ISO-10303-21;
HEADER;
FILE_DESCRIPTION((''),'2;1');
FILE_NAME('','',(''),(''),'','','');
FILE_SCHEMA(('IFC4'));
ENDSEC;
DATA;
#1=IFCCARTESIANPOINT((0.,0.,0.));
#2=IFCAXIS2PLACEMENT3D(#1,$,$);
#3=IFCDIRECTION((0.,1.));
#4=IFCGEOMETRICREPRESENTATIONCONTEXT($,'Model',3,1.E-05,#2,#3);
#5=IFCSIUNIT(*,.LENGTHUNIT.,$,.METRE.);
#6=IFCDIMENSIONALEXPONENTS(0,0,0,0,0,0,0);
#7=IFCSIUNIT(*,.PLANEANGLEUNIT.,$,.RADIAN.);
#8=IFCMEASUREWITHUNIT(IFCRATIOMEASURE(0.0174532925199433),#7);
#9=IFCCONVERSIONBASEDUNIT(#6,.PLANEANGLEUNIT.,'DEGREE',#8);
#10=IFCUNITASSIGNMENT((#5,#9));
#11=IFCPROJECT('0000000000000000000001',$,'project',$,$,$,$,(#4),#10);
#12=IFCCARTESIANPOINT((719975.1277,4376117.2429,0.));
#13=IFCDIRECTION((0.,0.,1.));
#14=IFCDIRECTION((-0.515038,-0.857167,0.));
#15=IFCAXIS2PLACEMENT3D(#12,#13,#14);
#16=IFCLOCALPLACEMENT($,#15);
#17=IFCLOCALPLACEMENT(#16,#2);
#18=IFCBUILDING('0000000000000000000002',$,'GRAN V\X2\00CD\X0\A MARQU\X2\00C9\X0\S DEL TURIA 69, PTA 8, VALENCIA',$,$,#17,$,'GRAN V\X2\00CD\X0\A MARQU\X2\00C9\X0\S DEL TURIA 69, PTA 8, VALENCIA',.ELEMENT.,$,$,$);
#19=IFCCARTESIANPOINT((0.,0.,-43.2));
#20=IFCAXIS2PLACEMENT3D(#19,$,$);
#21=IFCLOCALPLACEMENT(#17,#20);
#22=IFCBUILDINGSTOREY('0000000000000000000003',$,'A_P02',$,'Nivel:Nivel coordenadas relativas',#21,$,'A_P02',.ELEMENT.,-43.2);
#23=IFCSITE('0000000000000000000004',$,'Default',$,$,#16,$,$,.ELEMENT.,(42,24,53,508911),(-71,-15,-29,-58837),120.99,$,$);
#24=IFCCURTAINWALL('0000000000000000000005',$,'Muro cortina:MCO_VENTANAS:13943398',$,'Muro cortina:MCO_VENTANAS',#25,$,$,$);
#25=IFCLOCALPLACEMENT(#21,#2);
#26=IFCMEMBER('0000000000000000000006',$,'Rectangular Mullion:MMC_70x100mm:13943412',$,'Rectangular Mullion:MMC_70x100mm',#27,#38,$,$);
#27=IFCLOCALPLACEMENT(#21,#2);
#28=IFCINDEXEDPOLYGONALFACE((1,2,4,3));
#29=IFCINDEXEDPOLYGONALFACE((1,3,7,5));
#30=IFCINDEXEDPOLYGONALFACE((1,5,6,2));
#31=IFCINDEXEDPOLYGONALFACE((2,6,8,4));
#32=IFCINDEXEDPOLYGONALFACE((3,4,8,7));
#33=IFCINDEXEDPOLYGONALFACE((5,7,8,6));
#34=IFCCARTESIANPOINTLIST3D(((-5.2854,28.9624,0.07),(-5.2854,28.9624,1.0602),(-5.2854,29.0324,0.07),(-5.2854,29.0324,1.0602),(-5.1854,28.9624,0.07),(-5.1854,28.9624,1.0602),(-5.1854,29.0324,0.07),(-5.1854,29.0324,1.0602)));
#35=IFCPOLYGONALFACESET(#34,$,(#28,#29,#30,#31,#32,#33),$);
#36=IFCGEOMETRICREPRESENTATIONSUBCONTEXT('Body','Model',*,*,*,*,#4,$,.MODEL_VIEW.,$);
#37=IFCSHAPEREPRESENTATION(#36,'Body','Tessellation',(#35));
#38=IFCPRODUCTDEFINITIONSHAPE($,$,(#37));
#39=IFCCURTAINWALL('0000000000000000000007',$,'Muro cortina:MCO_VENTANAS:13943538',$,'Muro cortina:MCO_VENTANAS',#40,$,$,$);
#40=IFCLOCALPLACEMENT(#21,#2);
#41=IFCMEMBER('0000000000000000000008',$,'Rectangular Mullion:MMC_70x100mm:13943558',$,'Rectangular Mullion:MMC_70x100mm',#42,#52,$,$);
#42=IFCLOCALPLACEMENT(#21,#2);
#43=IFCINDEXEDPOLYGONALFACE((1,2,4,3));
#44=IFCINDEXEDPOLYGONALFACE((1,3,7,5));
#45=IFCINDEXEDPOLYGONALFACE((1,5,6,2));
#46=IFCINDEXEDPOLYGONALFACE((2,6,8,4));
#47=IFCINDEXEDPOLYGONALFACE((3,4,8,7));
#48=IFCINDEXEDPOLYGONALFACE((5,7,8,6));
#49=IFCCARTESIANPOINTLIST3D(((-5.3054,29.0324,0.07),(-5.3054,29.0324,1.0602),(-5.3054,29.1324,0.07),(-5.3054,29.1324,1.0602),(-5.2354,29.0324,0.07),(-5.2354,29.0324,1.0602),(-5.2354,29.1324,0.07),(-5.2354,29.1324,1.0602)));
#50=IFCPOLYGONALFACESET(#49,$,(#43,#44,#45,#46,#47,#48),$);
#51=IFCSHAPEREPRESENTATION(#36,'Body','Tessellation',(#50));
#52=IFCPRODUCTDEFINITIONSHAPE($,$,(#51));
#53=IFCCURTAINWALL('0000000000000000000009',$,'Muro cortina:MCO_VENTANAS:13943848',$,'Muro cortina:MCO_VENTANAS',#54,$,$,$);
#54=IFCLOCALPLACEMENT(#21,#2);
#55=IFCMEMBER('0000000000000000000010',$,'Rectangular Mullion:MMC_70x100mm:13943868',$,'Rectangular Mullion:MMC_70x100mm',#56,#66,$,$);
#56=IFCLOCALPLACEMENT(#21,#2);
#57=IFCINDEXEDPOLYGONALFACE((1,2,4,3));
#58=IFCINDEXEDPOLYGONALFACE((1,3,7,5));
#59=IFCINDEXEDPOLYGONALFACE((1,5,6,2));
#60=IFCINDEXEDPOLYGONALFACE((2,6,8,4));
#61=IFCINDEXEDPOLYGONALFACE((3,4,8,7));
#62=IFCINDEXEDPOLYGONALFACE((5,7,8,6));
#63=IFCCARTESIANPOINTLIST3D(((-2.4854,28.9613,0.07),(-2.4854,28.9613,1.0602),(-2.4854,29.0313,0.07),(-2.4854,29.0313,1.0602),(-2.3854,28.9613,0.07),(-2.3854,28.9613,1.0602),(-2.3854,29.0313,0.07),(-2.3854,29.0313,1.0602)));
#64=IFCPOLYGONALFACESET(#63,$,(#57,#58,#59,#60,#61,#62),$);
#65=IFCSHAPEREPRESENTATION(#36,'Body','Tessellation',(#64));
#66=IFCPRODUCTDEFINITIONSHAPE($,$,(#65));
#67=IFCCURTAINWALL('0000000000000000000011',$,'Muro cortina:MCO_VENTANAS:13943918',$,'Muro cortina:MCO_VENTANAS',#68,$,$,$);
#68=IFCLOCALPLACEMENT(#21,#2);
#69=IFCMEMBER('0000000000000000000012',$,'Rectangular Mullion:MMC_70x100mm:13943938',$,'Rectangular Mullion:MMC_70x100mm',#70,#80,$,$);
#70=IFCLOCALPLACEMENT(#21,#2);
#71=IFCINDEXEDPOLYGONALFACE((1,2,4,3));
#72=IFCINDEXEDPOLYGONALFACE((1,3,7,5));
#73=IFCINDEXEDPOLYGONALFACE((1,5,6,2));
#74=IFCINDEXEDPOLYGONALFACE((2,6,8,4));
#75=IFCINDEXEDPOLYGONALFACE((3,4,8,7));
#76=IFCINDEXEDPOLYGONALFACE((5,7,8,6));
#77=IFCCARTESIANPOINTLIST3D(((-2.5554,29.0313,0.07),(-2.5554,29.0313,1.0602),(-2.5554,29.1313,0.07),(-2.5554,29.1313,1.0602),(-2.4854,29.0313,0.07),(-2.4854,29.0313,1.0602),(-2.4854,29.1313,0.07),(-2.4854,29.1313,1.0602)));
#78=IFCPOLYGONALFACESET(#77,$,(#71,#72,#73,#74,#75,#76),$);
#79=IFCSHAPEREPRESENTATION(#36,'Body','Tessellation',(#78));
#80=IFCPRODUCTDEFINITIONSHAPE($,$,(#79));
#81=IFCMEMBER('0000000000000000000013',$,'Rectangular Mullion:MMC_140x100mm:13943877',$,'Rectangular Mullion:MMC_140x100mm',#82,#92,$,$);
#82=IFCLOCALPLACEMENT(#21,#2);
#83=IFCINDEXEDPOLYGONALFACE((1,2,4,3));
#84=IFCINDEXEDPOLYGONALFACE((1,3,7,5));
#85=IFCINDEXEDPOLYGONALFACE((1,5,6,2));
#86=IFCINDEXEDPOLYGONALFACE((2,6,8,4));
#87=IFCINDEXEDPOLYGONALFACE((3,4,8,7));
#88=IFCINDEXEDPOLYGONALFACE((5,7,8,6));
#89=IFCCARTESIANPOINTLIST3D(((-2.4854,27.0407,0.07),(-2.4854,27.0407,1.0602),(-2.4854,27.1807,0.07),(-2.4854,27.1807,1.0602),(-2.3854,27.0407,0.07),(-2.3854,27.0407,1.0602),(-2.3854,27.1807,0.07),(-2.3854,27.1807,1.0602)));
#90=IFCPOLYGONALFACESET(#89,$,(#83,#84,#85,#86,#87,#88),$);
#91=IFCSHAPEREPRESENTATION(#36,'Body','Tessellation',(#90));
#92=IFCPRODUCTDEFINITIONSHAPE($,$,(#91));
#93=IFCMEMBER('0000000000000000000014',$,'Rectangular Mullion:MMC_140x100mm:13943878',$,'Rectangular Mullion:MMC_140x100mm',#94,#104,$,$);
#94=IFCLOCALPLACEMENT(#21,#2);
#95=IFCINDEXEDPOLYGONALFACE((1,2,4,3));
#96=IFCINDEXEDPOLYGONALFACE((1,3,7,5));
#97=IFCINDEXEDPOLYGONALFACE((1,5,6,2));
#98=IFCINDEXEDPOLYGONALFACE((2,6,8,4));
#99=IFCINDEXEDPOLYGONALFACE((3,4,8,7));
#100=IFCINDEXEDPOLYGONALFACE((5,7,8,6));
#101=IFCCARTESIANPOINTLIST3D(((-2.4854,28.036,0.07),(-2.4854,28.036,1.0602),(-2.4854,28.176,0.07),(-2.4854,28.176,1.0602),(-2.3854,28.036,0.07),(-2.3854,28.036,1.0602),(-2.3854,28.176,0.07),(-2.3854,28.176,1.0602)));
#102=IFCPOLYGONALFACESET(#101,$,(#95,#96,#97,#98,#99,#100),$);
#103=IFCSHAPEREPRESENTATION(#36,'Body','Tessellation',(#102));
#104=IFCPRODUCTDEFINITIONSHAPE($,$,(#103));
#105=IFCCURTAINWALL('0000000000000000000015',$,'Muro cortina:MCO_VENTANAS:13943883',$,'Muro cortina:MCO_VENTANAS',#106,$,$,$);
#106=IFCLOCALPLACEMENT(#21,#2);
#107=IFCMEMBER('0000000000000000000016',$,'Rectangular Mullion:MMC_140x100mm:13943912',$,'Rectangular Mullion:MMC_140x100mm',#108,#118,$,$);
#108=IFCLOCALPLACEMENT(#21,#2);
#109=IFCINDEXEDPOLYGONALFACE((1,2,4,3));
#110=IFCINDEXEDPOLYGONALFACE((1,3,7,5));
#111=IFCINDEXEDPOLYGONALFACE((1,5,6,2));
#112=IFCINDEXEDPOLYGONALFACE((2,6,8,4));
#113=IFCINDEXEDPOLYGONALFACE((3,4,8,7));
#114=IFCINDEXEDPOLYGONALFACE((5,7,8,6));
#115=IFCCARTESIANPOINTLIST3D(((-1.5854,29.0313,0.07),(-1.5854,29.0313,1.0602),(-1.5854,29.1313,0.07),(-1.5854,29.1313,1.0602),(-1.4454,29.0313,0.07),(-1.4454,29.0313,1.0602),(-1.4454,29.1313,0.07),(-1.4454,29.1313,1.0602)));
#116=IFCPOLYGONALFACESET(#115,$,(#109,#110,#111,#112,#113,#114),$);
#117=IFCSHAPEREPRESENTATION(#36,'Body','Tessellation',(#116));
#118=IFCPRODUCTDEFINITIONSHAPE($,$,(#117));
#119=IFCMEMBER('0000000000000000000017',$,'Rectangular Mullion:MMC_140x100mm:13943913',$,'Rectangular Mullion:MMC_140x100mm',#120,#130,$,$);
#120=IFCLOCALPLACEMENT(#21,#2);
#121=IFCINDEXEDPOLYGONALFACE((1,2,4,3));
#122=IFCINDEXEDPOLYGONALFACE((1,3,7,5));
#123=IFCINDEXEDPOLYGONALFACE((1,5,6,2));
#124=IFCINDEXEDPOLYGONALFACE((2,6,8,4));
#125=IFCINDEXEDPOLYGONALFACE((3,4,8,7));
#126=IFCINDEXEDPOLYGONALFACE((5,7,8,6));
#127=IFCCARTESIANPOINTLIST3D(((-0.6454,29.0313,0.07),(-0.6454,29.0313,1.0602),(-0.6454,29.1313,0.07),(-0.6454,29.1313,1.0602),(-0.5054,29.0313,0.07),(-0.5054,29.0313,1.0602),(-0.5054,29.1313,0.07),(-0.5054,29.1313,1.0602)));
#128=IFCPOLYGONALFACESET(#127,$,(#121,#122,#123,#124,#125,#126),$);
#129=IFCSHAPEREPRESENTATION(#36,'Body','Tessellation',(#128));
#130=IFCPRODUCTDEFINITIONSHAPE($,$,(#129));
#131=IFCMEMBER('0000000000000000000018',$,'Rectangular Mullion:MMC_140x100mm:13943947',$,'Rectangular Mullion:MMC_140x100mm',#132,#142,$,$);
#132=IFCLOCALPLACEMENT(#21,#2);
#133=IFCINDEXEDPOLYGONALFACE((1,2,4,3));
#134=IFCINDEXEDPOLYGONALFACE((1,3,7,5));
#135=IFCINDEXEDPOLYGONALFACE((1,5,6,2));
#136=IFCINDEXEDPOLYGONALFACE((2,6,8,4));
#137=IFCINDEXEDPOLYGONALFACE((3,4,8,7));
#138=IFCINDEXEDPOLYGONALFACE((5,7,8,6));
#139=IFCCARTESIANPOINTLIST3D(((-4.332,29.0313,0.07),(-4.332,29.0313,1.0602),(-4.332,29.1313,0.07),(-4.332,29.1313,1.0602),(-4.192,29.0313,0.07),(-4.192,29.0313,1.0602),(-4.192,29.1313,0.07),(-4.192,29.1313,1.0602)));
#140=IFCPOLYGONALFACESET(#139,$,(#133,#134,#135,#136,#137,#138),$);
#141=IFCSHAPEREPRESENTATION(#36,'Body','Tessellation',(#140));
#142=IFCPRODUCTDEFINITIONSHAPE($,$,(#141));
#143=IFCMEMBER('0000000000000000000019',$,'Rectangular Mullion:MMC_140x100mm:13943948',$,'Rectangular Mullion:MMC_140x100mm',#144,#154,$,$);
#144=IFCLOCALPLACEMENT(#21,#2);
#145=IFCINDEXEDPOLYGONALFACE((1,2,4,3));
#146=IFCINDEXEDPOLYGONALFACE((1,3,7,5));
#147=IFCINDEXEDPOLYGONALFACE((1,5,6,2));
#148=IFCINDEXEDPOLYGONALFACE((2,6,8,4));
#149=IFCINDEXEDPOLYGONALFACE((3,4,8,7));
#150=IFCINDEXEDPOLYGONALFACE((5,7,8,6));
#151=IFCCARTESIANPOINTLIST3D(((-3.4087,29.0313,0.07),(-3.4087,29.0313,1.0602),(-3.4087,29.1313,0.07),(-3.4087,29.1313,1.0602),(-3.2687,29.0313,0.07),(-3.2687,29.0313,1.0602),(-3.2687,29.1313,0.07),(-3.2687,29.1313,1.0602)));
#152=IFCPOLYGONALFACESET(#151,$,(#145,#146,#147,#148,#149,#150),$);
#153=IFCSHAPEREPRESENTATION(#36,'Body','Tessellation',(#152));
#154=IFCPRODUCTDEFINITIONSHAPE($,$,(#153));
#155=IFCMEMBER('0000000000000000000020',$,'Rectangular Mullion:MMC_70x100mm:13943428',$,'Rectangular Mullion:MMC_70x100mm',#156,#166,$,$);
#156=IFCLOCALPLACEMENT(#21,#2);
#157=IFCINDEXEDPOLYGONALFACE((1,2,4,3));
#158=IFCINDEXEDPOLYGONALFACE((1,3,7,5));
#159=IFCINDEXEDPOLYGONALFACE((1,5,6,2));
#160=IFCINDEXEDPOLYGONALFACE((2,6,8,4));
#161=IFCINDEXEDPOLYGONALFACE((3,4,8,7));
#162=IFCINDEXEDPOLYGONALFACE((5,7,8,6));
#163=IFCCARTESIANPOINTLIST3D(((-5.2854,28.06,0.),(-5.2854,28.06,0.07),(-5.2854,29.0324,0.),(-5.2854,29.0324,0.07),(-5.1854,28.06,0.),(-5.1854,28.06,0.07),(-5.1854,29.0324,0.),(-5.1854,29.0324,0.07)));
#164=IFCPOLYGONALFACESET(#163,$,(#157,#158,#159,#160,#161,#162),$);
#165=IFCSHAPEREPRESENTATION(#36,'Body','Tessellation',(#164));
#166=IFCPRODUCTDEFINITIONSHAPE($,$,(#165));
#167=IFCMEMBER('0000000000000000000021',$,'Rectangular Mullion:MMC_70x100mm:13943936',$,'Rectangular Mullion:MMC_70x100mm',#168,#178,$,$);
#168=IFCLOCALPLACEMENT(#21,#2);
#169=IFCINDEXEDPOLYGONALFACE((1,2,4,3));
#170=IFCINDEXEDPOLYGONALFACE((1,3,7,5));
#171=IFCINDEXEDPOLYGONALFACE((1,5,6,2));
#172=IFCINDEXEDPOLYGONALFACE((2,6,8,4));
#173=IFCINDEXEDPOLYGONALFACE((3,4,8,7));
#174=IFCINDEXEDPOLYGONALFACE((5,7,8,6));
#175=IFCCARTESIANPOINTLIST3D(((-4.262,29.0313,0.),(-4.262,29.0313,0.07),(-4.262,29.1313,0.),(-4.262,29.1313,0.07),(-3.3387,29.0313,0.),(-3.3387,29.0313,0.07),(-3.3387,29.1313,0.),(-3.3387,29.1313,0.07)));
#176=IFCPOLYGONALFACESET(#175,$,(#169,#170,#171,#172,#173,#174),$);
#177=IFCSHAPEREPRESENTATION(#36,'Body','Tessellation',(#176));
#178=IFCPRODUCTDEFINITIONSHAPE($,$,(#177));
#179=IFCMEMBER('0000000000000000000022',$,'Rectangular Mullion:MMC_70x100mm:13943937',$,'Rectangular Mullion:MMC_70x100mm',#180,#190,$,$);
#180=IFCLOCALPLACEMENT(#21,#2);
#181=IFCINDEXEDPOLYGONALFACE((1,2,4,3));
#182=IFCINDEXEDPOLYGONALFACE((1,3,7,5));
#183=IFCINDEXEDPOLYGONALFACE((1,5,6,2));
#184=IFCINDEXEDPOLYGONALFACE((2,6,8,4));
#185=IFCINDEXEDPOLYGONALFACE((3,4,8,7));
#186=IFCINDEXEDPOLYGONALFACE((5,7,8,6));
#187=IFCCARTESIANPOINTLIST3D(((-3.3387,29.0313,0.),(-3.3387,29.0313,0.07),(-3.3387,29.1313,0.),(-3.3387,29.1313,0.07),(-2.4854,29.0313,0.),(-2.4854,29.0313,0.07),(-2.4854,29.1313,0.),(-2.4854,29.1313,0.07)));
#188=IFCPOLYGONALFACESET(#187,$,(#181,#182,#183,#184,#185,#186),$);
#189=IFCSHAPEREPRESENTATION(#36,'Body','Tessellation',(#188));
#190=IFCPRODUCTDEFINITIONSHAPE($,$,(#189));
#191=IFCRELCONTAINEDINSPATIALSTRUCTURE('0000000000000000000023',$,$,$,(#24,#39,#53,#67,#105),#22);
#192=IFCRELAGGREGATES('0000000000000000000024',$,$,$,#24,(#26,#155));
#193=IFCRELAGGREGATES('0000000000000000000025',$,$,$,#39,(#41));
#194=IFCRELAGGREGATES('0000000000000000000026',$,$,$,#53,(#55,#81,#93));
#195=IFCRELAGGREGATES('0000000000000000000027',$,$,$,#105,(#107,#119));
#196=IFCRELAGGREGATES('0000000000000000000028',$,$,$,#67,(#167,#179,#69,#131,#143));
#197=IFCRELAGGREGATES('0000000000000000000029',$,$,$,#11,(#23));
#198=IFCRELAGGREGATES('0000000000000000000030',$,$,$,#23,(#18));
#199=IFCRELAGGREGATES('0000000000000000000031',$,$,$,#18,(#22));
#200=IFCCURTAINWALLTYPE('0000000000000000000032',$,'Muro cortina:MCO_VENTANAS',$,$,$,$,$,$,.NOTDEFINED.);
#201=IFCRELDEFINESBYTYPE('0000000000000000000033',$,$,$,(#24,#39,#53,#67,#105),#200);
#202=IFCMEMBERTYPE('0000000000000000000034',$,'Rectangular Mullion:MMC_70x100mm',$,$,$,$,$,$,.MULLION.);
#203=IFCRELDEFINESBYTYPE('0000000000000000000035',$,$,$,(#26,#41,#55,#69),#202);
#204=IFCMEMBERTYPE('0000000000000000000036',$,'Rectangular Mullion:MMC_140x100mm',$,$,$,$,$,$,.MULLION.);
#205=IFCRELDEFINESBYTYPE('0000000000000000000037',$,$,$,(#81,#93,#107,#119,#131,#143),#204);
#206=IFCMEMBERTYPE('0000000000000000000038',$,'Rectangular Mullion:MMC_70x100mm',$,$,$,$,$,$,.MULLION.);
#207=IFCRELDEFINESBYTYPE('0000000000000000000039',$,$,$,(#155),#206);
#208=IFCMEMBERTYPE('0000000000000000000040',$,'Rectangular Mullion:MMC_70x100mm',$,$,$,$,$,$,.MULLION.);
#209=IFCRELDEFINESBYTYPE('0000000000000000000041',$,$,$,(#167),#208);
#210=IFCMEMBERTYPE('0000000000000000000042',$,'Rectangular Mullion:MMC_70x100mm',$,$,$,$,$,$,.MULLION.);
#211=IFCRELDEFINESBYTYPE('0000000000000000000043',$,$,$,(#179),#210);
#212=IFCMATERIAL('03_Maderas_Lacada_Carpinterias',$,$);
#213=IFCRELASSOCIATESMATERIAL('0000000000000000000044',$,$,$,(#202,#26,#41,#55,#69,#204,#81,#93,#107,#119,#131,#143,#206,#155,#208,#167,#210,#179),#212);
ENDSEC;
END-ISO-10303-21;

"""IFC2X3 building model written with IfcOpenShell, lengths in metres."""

from ifc_helpers import new_model, entity, si_unit, converted_unit, direction, frame, origin, origin_2d_with_axis, place, context, subcontext, project, spatial, rectangle, extrude, source, transform, mapped, material, type_object, type_shapes, element, aggregate, save


model = new_model("IFC2X3")

# Units and contexts
model_context = context("Model", 3, precision=1e-05, world=origin(), true_north=direction((0.0, 1.0)))
body_context = subcontext(model_context, "Body", "Model", "MODEL_VIEW")
ifc_project = project(units=[si_unit("LENGTHUNIT", "METRE"), converted_unit("PLANEANGLEUNIT", "DEGREE", entity("IfcRatioMeasure", 0.0174532925199433), si_unit("PLANEANGLEUNIT", "RADIAN"), dimensions=[0, 0, 0, 0, 0, 0, 0])], contexts=[model_context])

# Site, building, storey
site_placement = place(None, frame((719975.1277, 4376117.2429, 0.0), z_axis=(0.0, 0.0, 1.0), x_axis=(-0.515038, -0.857167, 0.0)))
site = spatial("IfcSite", under=ifc_project, at=site_placement, Name="Default", CompositionType="ELEMENT", RefLatitude=(42, 24, 53, 508911), RefLongitude=(-71, -15, -29, -58837), RefElevation=120.99)
building_placement = place(site_placement, origin())
building = spatial("IfcBuilding", under=site, at=building_placement, Name="GRAN VÍA MARQUÉS DEL TURIA 69, PTA 8, VALENCIA", LongName="GRAN VÍA MARQUÉS DEL TURIA 69, PTA 8, VALENCIA", CompositionType="ELEMENT")
storey_placement = place(building_placement, frame((0.0, 0.0, -43.2)))
storey = spatial("IfcBuildingStorey", under=building, at=storey_placement, Name="A_P02", ObjectType="Nivel:Nivel coordenadas relativas", LongName="A_P02", CompositionType="ELEMENT", Elevation=-43.2)

# Curtain walls, members
curtain_wall_type = type_object("IfcCurtainWallType", Name="Muro cortina:MCO_VENTANAS", PredefinedType="NOTDEFINED")
curtain_wall_1_placement = place(storey_placement, frame((0.0, 0.0, 43.2)))
curtain_wall_1 = element("IfcCurtainWall", 1, at=curtain_wall_1_placement, inside=storey, type_object=curtain_wall_type, Name="Muro cortina:MCO_VENTANAS:13943398", ObjectType="Muro cortina:MCO_VENTANAS")
ifc_material_1 = material(Name="03_Maderas_Lacada_Carpinterias")
member_type_1 = type_object("IfcMemberType", Name="Rectangular Mullion:MMC_70x100mm", PredefinedType="MULLION", material=ifc_material_1)
shared_shape_1 = source(origin(), body_context, "Body", "SweptSolid", [
    extrude(rectangle(XDim=0.1, YDim=0.07, at=origin_2d_with_axis()), frame((-0.035, 0.0, -0.9902), z_axis=(0.0, 0.0, 1.0), x_axis=(0.0, -1.0, 0.0)), (0.0, 0.0, 1.0), 0.9902),
])
type_shapes(member_type_1, [shared_shape_1])
member_1_placement = place(storey_placement, frame((-5.2354, 29.0324, 0.07), z_axis=(0.0, 0.0, -1.0), x_axis=(0.0, 1.0, 0.0)))
member_1 = element("IfcMember", 2, at=member_1_placement, type_object=member_type_1, material=ifc_material_1, Name="Rectangular Mullion:MMC_70x100mm:13943412", ObjectType="Rectangular Mullion:MMC_70x100mm", context=body_context, shape_type="MappedRepresentation", body=[
    mapped(shared_shape_1, transform((0.0, 0.0, 0.0), scale=1.0)),
])
curtain_wall_2_placement = place(storey_placement, frame((0.0, 0.0, 43.2)))
curtain_wall_2 = element("IfcCurtainWall", 3, at=curtain_wall_2_placement, inside=storey, type_object=curtain_wall_type, Name="Muro cortina:MCO_VENTANAS:13943538", ObjectType="Muro cortina:MCO_VENTANAS")
member_2_placement = place(storey_placement, frame((-5.2354, 29.0824, 0.07), z_axis=(0.0, 0.0, -1.0), x_axis=(1.0, 0.0, 0.0)))
member_2 = element("IfcMember", 4, at=member_2_placement, type_object=member_type_1, material=ifc_material_1, Name="Rectangular Mullion:MMC_70x100mm:13943558", ObjectType="Rectangular Mullion:MMC_70x100mm", context=body_context, shape_type="MappedRepresentation", body=[
    mapped(shared_shape_1, transform((0.0, 0.0, 0.0), scale=1.0)),
])
curtain_wall_3_placement = place(storey_placement, frame((0.0, 0.0, 43.2)))
curtain_wall_3 = element("IfcCurtainWall", 5, at=curtain_wall_3_placement, inside=storey, type_object=curtain_wall_type, Name="Muro cortina:MCO_VENTANAS:13943848", ObjectType="Muro cortina:MCO_VENTANAS")
member_3_placement = place(storey_placement, frame((-2.4354, 29.0313, 0.07), z_axis=(0.0, 0.0, -1.0), x_axis=(0.0, 1.0, 0.0)))
member_3 = element("IfcMember", 6, at=member_3_placement, type_object=member_type_1, material=ifc_material_1, Name="Rectangular Mullion:MMC_70x100mm:13943868", ObjectType="Rectangular Mullion:MMC_70x100mm", context=body_context, shape_type="MappedRepresentation", body=[
    mapped(shared_shape_1, transform((0.0, 0.0, 0.0), scale=1.0)),
])
curtain_wall_4_placement = place(storey_placement, frame((0.0, 0.0, 43.2)))
curtain_wall_4 = element("IfcCurtainWall", 7, at=curtain_wall_4_placement, inside=storey, type_object=curtain_wall_type, Name="Muro cortina:MCO_VENTANAS:13943918", ObjectType="Muro cortina:MCO_VENTANAS")
member_4_placement = place(storey_placement, frame((-2.4854, 29.0813, 0.07), z_axis=(0.0, 0.0, -1.0), x_axis=(1.0, 0.0, 0.0)))
member_4 = element("IfcMember", 8, at=member_4_placement, type_object=member_type_1, material=ifc_material_1, Name="Rectangular Mullion:MMC_70x100mm:13943938", ObjectType="Rectangular Mullion:MMC_70x100mm", context=body_context, shape_type="MappedRepresentation", body=[
    mapped(shared_shape_1, transform((0.0, 0.0, 0.0), scale=1.0)),
])

# Members
member_type_2 = type_object("IfcMemberType", Name="Rectangular Mullion:MMC_140x100mm", PredefinedType="MULLION", material=ifc_material_1)
shared_shape_2 = source(origin(), body_context, "Body", "SweptSolid", [
    extrude(rectangle(XDim=0.1, YDim=0.14, at=origin_2d_with_axis()), frame((0.0, 0.0, -0.9902), z_axis=(0.0, 0.0, 1.0), x_axis=(0.0, -1.0, 0.0)), (0.0, 0.0, 1.0), 0.9902),
])
type_shapes(member_type_2, [shared_shape_2])
member_5_placement = place(storey_placement, frame((-2.4354, 27.1107, 0.07), z_axis=(0.0, 0.0, -1.0), x_axis=(0.0, 1.0, 0.0)))
member_5 = element("IfcMember", 9, at=member_5_placement, type_object=member_type_2, material=ifc_material_1, Name="Rectangular Mullion:MMC_140x100mm:13943877", ObjectType="Rectangular Mullion:MMC_140x100mm", context=body_context, shape_type="MappedRepresentation", body=[
    mapped(shared_shape_2, transform((0.0, 0.0, 0.0), scale=1.0)),
])
member_6_placement = place(storey_placement, frame((-2.4354, 28.106, 0.07), z_axis=(0.0, 0.0, -1.0), x_axis=(0.0, 1.0, 0.0)))
member_6 = element("IfcMember", 10, at=member_6_placement, type_object=member_type_2, material=ifc_material_1, Name="Rectangular Mullion:MMC_140x100mm:13943878", ObjectType="Rectangular Mullion:MMC_140x100mm", context=body_context, shape_type="MappedRepresentation", body=[
    mapped(shared_shape_2, transform((0.0, 0.0, 0.0), scale=1.0)),
])

# Curtain wall, members
curtain_wall_5_placement = place(storey_placement, frame((0.0, 0.0, 43.2)))
curtain_wall_5 = element("IfcCurtainWall", 11, at=curtain_wall_5_placement, inside=storey, type_object=curtain_wall_type, Name="Muro cortina:MCO_VENTANAS:13943883", ObjectType="Muro cortina:MCO_VENTANAS")
member_7_placement = place(storey_placement, frame((-1.5154, 29.0813, 0.07), z_axis=(0.0, 0.0, -1.0), x_axis=(1.0, 0.0, 0.0)))
member_7 = element("IfcMember", 12, at=member_7_placement, type_object=member_type_2, material=ifc_material_1, Name="Rectangular Mullion:MMC_140x100mm:13943912", ObjectType="Rectangular Mullion:MMC_140x100mm", context=body_context, shape_type="MappedRepresentation", body=[
    mapped(shared_shape_2, transform((0.0, 0.0, 0.0), scale=1.0)),
])
member_8_placement = place(storey_placement, frame((-0.5754, 29.0813, 0.07), z_axis=(0.0, 0.0, -1.0), x_axis=(1.0, 0.0, 0.0)))
member_8 = element("IfcMember", 13, at=member_8_placement, type_object=member_type_2, material=ifc_material_1, Name="Rectangular Mullion:MMC_140x100mm:13943913", ObjectType="Rectangular Mullion:MMC_140x100mm", context=body_context, shape_type="MappedRepresentation", body=[
    mapped(shared_shape_2, transform((0.0, 0.0, 0.0), scale=1.0)),
])

# Members
member_9_placement = place(storey_placement, frame((-4.262, 29.0813, 0.07), z_axis=(0.0, 0.0, -1.0), x_axis=(1.0, 0.0, 0.0)))
member_9 = element("IfcMember", 14, at=member_9_placement, type_object=member_type_2, material=ifc_material_1, Name="Rectangular Mullion:MMC_140x100mm:13943947", ObjectType="Rectangular Mullion:MMC_140x100mm", context=body_context, shape_type="MappedRepresentation", body=[
    mapped(shared_shape_2, transform((0.0, 0.0, 0.0), scale=1.0)),
])
member_10_placement = place(storey_placement, frame((-3.3387, 29.0813, 0.07), z_axis=(0.0, 0.0, -1.0), x_axis=(1.0, 0.0, 0.0)))
member_10 = element("IfcMember", 15, at=member_10_placement, type_object=member_type_2, material=ifc_material_1, Name="Rectangular Mullion:MMC_140x100mm:13943948", ObjectType="Rectangular Mullion:MMC_140x100mm", context=body_context, shape_type="MappedRepresentation", body=[
    mapped(shared_shape_2, transform((0.0, 0.0, 0.0), scale=1.0)),
])
member_type_3 = type_object("IfcMemberType", Name="Rectangular Mullion:MMC_70x100mm", PredefinedType="MULLION", material=ifc_material_1)
shared_shape_3 = source(origin(), body_context, "Body", "SweptSolid", [
    extrude(rectangle(XDim=0.1, YDim=0.07, at=origin_2d_with_axis()), frame((-0.035, 0.0, -0.9723), z_axis=(0.0, 0.0, 1.0), x_axis=(0.0, -1.0, 0.0)), (0.0, 0.0, 1.0), 0.9723),
])
type_shapes(member_type_3, [shared_shape_3])
member_11_placement = place(storey_placement, frame((-5.2354, 28.06, 0.0), z_axis=(0.0, -1.0, 0.0), x_axis=(0.0, 0.0, -1.0)))
member_11 = element("IfcMember", 16, at=member_11_placement, type_object=member_type_3, material=ifc_material_1, Name="Rectangular Mullion:MMC_70x100mm:13943428", ObjectType="Rectangular Mullion:MMC_70x100mm", context=body_context, shape_type="MappedRepresentation", body=[
    mapped(shared_shape_3, transform((0.0, 0.0, 0.0), scale=1.0)),
])
member_type_4 = type_object("IfcMemberType", Name="Rectangular Mullion:MMC_70x100mm", PredefinedType="MULLION", material=ifc_material_1)
shared_shape_4 = source(origin(), body_context, "Body", "SweptSolid", [
    extrude(rectangle(XDim=0.1, YDim=0.07, at=origin_2d_with_axis()), frame((-0.035, 0.0, -0.9233), z_axis=(0.0, 0.0, 1.0), x_axis=(0.0, -1.0, 0.0)), (0.0, 0.0, 1.0), 0.9233),
])
type_shapes(member_type_4, [shared_shape_4])
member_12_placement = place(storey_placement, frame((-4.262, 29.0813, 0.0), z_axis=(-1.0, 0.0, 0.0), x_axis=(0.0, 0.0, -1.0)))
member_12 = element("IfcMember", 17, at=member_12_placement, type_object=member_type_4, material=ifc_material_1, Name="Rectangular Mullion:MMC_70x100mm:13943936", ObjectType="Rectangular Mullion:MMC_70x100mm", context=body_context, shape_type="MappedRepresentation", body=[
    mapped(shared_shape_4, transform((0.0, 0.0, 0.0), scale=1.0)),
])
member_type_5 = type_object("IfcMemberType", Name="Rectangular Mullion:MMC_70x100mm", PredefinedType="MULLION", material=ifc_material_1)
shared_shape_5 = source(origin(), body_context, "Body", "SweptSolid", [
    extrude(rectangle(XDim=0.1, YDim=0.07, at=origin_2d_with_axis()), frame((-0.035, 0.0, -0.8533), z_axis=(0.0, 0.0, 1.0), x_axis=(0.0, -1.0, 0.0)), (0.0, 0.0, 1.0), 0.8533),
])
type_shapes(member_type_5, [shared_shape_5])
member_13_placement = place(storey_placement, frame((-3.3387, 29.0813, 0.0), z_axis=(-1.0, 0.0, 0.0), x_axis=(0.0, 0.0, -1.0)))
member_13 = element("IfcMember", 18, at=member_13_placement, type_object=member_type_5, material=ifc_material_1, Name="Rectangular Mullion:MMC_70x100mm:13943937", ObjectType="Rectangular Mullion:MMC_70x100mm", context=body_context, shape_type="MappedRepresentation", body=[
    mapped(shared_shape_5, transform((0.0, 0.0, 0.0), scale=1.0)),
])

aggregate(curtain_wall_1, [member_1, member_11])

aggregate(curtain_wall_2, [member_2])
aggregate(curtain_wall_3, [member_3, member_5, member_6])
aggregate(curtain_wall_5, [member_7, member_8])
aggregate(curtain_wall_4, [member_12, member_13, member_4, member_9, member_10])

save(model, "model.ifc")
